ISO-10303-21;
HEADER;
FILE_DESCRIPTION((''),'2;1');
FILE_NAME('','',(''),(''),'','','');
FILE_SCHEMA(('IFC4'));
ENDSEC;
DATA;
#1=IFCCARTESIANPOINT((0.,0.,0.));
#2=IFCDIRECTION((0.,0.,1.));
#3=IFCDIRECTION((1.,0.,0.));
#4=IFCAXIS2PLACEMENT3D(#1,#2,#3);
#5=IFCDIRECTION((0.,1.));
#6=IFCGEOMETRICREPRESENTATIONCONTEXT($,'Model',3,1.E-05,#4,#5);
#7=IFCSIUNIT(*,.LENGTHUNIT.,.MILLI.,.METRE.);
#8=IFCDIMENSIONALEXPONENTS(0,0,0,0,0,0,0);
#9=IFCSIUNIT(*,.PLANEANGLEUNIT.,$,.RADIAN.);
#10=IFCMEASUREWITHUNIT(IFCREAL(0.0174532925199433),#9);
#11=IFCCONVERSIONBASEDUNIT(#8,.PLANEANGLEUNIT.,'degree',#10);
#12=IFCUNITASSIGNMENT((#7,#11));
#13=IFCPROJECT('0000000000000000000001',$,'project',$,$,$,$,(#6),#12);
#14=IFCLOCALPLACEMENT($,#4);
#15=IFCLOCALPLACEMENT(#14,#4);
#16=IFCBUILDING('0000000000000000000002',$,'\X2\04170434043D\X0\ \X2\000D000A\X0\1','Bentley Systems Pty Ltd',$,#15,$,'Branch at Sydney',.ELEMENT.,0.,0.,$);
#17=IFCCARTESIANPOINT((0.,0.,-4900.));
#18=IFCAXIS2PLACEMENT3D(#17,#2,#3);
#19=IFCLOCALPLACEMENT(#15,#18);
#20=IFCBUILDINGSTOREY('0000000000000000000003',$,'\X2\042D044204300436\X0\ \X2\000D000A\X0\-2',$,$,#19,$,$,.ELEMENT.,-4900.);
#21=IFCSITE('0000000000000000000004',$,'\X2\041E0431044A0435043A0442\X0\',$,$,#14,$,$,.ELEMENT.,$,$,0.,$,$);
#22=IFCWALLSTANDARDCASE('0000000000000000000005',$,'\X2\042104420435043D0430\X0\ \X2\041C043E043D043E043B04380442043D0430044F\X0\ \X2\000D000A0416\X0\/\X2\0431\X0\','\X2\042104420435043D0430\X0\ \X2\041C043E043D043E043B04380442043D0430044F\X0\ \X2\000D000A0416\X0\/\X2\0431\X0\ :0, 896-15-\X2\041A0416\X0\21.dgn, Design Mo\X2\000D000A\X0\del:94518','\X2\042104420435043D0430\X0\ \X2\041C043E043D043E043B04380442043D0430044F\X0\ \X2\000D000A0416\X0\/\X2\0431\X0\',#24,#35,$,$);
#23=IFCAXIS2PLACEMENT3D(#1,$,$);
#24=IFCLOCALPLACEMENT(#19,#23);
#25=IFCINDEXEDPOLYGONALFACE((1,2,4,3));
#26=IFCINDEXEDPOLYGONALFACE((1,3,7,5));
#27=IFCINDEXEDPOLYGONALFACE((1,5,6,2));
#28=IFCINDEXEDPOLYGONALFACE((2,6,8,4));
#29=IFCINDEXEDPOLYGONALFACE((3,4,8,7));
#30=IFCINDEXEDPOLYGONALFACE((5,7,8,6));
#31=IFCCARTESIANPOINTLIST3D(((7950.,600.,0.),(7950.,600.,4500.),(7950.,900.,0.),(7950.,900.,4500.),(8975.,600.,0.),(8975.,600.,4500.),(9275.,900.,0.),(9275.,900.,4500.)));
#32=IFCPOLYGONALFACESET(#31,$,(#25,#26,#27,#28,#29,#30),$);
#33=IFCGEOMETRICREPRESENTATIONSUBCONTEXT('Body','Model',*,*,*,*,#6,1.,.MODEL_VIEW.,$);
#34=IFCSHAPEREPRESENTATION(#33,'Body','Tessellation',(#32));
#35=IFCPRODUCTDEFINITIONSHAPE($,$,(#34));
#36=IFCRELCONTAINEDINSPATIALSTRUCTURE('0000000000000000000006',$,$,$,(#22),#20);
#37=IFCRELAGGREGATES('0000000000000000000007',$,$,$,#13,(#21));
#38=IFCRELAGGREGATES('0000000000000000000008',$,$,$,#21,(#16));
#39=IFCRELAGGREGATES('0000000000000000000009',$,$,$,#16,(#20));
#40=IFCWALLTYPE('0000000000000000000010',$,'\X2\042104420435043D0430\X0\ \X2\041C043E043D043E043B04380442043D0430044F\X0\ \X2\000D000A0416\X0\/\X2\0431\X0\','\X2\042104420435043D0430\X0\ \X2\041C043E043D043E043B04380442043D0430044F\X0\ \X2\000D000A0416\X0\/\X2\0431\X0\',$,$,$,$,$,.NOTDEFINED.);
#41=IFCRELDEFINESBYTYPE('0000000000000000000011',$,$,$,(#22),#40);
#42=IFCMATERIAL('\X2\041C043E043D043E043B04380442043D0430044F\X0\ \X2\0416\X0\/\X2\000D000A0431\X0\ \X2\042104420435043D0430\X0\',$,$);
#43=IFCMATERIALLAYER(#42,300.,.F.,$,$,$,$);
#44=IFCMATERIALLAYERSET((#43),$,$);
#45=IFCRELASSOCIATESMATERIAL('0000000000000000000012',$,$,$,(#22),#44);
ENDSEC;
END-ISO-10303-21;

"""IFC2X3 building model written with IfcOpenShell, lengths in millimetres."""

from ifc_helpers import new_model, entity, si_unit, converted_unit, direction, frame, origin_with_axes, place, context, subcontext, project, spatial, polyline, outline, extrude, material, layer, layer_set, layer_usage, type_object, element, save


model = new_model("IFC2X3")

# Units and contexts
model_context = context("Model", 3, precision=1e-05, world=origin_with_axes(), true_north=direction((0.0, 1.0)))
body_context = subcontext(model_context, "Body", "Model", "MODEL_VIEW", scale=1.0)
ifc_project = project(units=[si_unit("LENGTHUNIT", "METRE", prefix="MILLI"), converted_unit("PLANEANGLEUNIT", "degree", entity("IfcReal", 0.0174532925199433), si_unit("PLANEANGLEUNIT", "RADIAN"), dimensions=[0, 0, 0, 0, 0, 0, 0])], contexts=[model_context])

# Site, building, storey
site_placement = place(None, origin_with_axes())
site = spatial("IfcSite", under=ifc_project, at=site_placement, Name="Объект", CompositionType="ELEMENT", RefElevation=0.0)
building_placement = place(site_placement, origin_with_axes())
building = spatial("IfcBuilding", under=site, at=building_placement, Name="Здн \r\n1", Description="Bentley Systems Pty Ltd", LongName="Branch at Sydney", CompositionType="ELEMENT", ElevationOfRefHeight=0.0, ElevationOfTerrain=0.0)
storey_placement = place(building_placement, frame((0.0, 0.0, -4900.0), z_axis=(0.0, 0.0, 1.0), x_axis=(1.0, 0.0, 0.0)))
storey = spatial("IfcBuildingStorey", under=building, at=storey_placement, Name="Этаж \r\n-2", CompositionType="ELEMENT", Elevation=-4900.0)

# Wall
ifc_material = material(Name="Монолитная Ж/\r\nб Стена")
ifc_layer = layer(ifc_material, 300.0, ventilated=False)
ifc_layer_set = layer_set([ifc_layer])
ifc_layer_usage = layer_usage(ifc_layer_set, "AXIS2", "POSITIVE", 0.0)
wall_type = type_object("IfcWallType", Name="Стена Монолитная \r\nЖ/б", Description="Стена Монолитная \r\nЖ/б", PredefinedType="NOTDEFINED")
wall_placement = place(storey_placement, frame((7950.0, 600.0, 0.0), z_axis=(0.0, 0.0, 1.0), x_axis=(1.0, 0.0, 0.0)))
element("IfcWallStandardCase", 1, at=wall_placement, inside=storey, type_object=wall_type, material=ifc_layer_usage, Name="Стена Монолитная \r\nЖ/б", Description="Стена Монолитная \r\nЖ/б :0, 896-15-КЖ21.dgn, Design Mo\r\ndel:94518", ObjectType="Стена Монолитная \r\nЖ/б", context=body_context, shape_type="SweptSolid", body=[
    extrude(outline(polyline([(1325.0, 300.0), (0.0, 300.0), (0.0, 0.0), (1025.0, 0.0), (1325.0, 300.0)])), origin_with_axes(), (0.0, 0.0, 1.0), 4500.0),
])

save(model, "model.ifc")
